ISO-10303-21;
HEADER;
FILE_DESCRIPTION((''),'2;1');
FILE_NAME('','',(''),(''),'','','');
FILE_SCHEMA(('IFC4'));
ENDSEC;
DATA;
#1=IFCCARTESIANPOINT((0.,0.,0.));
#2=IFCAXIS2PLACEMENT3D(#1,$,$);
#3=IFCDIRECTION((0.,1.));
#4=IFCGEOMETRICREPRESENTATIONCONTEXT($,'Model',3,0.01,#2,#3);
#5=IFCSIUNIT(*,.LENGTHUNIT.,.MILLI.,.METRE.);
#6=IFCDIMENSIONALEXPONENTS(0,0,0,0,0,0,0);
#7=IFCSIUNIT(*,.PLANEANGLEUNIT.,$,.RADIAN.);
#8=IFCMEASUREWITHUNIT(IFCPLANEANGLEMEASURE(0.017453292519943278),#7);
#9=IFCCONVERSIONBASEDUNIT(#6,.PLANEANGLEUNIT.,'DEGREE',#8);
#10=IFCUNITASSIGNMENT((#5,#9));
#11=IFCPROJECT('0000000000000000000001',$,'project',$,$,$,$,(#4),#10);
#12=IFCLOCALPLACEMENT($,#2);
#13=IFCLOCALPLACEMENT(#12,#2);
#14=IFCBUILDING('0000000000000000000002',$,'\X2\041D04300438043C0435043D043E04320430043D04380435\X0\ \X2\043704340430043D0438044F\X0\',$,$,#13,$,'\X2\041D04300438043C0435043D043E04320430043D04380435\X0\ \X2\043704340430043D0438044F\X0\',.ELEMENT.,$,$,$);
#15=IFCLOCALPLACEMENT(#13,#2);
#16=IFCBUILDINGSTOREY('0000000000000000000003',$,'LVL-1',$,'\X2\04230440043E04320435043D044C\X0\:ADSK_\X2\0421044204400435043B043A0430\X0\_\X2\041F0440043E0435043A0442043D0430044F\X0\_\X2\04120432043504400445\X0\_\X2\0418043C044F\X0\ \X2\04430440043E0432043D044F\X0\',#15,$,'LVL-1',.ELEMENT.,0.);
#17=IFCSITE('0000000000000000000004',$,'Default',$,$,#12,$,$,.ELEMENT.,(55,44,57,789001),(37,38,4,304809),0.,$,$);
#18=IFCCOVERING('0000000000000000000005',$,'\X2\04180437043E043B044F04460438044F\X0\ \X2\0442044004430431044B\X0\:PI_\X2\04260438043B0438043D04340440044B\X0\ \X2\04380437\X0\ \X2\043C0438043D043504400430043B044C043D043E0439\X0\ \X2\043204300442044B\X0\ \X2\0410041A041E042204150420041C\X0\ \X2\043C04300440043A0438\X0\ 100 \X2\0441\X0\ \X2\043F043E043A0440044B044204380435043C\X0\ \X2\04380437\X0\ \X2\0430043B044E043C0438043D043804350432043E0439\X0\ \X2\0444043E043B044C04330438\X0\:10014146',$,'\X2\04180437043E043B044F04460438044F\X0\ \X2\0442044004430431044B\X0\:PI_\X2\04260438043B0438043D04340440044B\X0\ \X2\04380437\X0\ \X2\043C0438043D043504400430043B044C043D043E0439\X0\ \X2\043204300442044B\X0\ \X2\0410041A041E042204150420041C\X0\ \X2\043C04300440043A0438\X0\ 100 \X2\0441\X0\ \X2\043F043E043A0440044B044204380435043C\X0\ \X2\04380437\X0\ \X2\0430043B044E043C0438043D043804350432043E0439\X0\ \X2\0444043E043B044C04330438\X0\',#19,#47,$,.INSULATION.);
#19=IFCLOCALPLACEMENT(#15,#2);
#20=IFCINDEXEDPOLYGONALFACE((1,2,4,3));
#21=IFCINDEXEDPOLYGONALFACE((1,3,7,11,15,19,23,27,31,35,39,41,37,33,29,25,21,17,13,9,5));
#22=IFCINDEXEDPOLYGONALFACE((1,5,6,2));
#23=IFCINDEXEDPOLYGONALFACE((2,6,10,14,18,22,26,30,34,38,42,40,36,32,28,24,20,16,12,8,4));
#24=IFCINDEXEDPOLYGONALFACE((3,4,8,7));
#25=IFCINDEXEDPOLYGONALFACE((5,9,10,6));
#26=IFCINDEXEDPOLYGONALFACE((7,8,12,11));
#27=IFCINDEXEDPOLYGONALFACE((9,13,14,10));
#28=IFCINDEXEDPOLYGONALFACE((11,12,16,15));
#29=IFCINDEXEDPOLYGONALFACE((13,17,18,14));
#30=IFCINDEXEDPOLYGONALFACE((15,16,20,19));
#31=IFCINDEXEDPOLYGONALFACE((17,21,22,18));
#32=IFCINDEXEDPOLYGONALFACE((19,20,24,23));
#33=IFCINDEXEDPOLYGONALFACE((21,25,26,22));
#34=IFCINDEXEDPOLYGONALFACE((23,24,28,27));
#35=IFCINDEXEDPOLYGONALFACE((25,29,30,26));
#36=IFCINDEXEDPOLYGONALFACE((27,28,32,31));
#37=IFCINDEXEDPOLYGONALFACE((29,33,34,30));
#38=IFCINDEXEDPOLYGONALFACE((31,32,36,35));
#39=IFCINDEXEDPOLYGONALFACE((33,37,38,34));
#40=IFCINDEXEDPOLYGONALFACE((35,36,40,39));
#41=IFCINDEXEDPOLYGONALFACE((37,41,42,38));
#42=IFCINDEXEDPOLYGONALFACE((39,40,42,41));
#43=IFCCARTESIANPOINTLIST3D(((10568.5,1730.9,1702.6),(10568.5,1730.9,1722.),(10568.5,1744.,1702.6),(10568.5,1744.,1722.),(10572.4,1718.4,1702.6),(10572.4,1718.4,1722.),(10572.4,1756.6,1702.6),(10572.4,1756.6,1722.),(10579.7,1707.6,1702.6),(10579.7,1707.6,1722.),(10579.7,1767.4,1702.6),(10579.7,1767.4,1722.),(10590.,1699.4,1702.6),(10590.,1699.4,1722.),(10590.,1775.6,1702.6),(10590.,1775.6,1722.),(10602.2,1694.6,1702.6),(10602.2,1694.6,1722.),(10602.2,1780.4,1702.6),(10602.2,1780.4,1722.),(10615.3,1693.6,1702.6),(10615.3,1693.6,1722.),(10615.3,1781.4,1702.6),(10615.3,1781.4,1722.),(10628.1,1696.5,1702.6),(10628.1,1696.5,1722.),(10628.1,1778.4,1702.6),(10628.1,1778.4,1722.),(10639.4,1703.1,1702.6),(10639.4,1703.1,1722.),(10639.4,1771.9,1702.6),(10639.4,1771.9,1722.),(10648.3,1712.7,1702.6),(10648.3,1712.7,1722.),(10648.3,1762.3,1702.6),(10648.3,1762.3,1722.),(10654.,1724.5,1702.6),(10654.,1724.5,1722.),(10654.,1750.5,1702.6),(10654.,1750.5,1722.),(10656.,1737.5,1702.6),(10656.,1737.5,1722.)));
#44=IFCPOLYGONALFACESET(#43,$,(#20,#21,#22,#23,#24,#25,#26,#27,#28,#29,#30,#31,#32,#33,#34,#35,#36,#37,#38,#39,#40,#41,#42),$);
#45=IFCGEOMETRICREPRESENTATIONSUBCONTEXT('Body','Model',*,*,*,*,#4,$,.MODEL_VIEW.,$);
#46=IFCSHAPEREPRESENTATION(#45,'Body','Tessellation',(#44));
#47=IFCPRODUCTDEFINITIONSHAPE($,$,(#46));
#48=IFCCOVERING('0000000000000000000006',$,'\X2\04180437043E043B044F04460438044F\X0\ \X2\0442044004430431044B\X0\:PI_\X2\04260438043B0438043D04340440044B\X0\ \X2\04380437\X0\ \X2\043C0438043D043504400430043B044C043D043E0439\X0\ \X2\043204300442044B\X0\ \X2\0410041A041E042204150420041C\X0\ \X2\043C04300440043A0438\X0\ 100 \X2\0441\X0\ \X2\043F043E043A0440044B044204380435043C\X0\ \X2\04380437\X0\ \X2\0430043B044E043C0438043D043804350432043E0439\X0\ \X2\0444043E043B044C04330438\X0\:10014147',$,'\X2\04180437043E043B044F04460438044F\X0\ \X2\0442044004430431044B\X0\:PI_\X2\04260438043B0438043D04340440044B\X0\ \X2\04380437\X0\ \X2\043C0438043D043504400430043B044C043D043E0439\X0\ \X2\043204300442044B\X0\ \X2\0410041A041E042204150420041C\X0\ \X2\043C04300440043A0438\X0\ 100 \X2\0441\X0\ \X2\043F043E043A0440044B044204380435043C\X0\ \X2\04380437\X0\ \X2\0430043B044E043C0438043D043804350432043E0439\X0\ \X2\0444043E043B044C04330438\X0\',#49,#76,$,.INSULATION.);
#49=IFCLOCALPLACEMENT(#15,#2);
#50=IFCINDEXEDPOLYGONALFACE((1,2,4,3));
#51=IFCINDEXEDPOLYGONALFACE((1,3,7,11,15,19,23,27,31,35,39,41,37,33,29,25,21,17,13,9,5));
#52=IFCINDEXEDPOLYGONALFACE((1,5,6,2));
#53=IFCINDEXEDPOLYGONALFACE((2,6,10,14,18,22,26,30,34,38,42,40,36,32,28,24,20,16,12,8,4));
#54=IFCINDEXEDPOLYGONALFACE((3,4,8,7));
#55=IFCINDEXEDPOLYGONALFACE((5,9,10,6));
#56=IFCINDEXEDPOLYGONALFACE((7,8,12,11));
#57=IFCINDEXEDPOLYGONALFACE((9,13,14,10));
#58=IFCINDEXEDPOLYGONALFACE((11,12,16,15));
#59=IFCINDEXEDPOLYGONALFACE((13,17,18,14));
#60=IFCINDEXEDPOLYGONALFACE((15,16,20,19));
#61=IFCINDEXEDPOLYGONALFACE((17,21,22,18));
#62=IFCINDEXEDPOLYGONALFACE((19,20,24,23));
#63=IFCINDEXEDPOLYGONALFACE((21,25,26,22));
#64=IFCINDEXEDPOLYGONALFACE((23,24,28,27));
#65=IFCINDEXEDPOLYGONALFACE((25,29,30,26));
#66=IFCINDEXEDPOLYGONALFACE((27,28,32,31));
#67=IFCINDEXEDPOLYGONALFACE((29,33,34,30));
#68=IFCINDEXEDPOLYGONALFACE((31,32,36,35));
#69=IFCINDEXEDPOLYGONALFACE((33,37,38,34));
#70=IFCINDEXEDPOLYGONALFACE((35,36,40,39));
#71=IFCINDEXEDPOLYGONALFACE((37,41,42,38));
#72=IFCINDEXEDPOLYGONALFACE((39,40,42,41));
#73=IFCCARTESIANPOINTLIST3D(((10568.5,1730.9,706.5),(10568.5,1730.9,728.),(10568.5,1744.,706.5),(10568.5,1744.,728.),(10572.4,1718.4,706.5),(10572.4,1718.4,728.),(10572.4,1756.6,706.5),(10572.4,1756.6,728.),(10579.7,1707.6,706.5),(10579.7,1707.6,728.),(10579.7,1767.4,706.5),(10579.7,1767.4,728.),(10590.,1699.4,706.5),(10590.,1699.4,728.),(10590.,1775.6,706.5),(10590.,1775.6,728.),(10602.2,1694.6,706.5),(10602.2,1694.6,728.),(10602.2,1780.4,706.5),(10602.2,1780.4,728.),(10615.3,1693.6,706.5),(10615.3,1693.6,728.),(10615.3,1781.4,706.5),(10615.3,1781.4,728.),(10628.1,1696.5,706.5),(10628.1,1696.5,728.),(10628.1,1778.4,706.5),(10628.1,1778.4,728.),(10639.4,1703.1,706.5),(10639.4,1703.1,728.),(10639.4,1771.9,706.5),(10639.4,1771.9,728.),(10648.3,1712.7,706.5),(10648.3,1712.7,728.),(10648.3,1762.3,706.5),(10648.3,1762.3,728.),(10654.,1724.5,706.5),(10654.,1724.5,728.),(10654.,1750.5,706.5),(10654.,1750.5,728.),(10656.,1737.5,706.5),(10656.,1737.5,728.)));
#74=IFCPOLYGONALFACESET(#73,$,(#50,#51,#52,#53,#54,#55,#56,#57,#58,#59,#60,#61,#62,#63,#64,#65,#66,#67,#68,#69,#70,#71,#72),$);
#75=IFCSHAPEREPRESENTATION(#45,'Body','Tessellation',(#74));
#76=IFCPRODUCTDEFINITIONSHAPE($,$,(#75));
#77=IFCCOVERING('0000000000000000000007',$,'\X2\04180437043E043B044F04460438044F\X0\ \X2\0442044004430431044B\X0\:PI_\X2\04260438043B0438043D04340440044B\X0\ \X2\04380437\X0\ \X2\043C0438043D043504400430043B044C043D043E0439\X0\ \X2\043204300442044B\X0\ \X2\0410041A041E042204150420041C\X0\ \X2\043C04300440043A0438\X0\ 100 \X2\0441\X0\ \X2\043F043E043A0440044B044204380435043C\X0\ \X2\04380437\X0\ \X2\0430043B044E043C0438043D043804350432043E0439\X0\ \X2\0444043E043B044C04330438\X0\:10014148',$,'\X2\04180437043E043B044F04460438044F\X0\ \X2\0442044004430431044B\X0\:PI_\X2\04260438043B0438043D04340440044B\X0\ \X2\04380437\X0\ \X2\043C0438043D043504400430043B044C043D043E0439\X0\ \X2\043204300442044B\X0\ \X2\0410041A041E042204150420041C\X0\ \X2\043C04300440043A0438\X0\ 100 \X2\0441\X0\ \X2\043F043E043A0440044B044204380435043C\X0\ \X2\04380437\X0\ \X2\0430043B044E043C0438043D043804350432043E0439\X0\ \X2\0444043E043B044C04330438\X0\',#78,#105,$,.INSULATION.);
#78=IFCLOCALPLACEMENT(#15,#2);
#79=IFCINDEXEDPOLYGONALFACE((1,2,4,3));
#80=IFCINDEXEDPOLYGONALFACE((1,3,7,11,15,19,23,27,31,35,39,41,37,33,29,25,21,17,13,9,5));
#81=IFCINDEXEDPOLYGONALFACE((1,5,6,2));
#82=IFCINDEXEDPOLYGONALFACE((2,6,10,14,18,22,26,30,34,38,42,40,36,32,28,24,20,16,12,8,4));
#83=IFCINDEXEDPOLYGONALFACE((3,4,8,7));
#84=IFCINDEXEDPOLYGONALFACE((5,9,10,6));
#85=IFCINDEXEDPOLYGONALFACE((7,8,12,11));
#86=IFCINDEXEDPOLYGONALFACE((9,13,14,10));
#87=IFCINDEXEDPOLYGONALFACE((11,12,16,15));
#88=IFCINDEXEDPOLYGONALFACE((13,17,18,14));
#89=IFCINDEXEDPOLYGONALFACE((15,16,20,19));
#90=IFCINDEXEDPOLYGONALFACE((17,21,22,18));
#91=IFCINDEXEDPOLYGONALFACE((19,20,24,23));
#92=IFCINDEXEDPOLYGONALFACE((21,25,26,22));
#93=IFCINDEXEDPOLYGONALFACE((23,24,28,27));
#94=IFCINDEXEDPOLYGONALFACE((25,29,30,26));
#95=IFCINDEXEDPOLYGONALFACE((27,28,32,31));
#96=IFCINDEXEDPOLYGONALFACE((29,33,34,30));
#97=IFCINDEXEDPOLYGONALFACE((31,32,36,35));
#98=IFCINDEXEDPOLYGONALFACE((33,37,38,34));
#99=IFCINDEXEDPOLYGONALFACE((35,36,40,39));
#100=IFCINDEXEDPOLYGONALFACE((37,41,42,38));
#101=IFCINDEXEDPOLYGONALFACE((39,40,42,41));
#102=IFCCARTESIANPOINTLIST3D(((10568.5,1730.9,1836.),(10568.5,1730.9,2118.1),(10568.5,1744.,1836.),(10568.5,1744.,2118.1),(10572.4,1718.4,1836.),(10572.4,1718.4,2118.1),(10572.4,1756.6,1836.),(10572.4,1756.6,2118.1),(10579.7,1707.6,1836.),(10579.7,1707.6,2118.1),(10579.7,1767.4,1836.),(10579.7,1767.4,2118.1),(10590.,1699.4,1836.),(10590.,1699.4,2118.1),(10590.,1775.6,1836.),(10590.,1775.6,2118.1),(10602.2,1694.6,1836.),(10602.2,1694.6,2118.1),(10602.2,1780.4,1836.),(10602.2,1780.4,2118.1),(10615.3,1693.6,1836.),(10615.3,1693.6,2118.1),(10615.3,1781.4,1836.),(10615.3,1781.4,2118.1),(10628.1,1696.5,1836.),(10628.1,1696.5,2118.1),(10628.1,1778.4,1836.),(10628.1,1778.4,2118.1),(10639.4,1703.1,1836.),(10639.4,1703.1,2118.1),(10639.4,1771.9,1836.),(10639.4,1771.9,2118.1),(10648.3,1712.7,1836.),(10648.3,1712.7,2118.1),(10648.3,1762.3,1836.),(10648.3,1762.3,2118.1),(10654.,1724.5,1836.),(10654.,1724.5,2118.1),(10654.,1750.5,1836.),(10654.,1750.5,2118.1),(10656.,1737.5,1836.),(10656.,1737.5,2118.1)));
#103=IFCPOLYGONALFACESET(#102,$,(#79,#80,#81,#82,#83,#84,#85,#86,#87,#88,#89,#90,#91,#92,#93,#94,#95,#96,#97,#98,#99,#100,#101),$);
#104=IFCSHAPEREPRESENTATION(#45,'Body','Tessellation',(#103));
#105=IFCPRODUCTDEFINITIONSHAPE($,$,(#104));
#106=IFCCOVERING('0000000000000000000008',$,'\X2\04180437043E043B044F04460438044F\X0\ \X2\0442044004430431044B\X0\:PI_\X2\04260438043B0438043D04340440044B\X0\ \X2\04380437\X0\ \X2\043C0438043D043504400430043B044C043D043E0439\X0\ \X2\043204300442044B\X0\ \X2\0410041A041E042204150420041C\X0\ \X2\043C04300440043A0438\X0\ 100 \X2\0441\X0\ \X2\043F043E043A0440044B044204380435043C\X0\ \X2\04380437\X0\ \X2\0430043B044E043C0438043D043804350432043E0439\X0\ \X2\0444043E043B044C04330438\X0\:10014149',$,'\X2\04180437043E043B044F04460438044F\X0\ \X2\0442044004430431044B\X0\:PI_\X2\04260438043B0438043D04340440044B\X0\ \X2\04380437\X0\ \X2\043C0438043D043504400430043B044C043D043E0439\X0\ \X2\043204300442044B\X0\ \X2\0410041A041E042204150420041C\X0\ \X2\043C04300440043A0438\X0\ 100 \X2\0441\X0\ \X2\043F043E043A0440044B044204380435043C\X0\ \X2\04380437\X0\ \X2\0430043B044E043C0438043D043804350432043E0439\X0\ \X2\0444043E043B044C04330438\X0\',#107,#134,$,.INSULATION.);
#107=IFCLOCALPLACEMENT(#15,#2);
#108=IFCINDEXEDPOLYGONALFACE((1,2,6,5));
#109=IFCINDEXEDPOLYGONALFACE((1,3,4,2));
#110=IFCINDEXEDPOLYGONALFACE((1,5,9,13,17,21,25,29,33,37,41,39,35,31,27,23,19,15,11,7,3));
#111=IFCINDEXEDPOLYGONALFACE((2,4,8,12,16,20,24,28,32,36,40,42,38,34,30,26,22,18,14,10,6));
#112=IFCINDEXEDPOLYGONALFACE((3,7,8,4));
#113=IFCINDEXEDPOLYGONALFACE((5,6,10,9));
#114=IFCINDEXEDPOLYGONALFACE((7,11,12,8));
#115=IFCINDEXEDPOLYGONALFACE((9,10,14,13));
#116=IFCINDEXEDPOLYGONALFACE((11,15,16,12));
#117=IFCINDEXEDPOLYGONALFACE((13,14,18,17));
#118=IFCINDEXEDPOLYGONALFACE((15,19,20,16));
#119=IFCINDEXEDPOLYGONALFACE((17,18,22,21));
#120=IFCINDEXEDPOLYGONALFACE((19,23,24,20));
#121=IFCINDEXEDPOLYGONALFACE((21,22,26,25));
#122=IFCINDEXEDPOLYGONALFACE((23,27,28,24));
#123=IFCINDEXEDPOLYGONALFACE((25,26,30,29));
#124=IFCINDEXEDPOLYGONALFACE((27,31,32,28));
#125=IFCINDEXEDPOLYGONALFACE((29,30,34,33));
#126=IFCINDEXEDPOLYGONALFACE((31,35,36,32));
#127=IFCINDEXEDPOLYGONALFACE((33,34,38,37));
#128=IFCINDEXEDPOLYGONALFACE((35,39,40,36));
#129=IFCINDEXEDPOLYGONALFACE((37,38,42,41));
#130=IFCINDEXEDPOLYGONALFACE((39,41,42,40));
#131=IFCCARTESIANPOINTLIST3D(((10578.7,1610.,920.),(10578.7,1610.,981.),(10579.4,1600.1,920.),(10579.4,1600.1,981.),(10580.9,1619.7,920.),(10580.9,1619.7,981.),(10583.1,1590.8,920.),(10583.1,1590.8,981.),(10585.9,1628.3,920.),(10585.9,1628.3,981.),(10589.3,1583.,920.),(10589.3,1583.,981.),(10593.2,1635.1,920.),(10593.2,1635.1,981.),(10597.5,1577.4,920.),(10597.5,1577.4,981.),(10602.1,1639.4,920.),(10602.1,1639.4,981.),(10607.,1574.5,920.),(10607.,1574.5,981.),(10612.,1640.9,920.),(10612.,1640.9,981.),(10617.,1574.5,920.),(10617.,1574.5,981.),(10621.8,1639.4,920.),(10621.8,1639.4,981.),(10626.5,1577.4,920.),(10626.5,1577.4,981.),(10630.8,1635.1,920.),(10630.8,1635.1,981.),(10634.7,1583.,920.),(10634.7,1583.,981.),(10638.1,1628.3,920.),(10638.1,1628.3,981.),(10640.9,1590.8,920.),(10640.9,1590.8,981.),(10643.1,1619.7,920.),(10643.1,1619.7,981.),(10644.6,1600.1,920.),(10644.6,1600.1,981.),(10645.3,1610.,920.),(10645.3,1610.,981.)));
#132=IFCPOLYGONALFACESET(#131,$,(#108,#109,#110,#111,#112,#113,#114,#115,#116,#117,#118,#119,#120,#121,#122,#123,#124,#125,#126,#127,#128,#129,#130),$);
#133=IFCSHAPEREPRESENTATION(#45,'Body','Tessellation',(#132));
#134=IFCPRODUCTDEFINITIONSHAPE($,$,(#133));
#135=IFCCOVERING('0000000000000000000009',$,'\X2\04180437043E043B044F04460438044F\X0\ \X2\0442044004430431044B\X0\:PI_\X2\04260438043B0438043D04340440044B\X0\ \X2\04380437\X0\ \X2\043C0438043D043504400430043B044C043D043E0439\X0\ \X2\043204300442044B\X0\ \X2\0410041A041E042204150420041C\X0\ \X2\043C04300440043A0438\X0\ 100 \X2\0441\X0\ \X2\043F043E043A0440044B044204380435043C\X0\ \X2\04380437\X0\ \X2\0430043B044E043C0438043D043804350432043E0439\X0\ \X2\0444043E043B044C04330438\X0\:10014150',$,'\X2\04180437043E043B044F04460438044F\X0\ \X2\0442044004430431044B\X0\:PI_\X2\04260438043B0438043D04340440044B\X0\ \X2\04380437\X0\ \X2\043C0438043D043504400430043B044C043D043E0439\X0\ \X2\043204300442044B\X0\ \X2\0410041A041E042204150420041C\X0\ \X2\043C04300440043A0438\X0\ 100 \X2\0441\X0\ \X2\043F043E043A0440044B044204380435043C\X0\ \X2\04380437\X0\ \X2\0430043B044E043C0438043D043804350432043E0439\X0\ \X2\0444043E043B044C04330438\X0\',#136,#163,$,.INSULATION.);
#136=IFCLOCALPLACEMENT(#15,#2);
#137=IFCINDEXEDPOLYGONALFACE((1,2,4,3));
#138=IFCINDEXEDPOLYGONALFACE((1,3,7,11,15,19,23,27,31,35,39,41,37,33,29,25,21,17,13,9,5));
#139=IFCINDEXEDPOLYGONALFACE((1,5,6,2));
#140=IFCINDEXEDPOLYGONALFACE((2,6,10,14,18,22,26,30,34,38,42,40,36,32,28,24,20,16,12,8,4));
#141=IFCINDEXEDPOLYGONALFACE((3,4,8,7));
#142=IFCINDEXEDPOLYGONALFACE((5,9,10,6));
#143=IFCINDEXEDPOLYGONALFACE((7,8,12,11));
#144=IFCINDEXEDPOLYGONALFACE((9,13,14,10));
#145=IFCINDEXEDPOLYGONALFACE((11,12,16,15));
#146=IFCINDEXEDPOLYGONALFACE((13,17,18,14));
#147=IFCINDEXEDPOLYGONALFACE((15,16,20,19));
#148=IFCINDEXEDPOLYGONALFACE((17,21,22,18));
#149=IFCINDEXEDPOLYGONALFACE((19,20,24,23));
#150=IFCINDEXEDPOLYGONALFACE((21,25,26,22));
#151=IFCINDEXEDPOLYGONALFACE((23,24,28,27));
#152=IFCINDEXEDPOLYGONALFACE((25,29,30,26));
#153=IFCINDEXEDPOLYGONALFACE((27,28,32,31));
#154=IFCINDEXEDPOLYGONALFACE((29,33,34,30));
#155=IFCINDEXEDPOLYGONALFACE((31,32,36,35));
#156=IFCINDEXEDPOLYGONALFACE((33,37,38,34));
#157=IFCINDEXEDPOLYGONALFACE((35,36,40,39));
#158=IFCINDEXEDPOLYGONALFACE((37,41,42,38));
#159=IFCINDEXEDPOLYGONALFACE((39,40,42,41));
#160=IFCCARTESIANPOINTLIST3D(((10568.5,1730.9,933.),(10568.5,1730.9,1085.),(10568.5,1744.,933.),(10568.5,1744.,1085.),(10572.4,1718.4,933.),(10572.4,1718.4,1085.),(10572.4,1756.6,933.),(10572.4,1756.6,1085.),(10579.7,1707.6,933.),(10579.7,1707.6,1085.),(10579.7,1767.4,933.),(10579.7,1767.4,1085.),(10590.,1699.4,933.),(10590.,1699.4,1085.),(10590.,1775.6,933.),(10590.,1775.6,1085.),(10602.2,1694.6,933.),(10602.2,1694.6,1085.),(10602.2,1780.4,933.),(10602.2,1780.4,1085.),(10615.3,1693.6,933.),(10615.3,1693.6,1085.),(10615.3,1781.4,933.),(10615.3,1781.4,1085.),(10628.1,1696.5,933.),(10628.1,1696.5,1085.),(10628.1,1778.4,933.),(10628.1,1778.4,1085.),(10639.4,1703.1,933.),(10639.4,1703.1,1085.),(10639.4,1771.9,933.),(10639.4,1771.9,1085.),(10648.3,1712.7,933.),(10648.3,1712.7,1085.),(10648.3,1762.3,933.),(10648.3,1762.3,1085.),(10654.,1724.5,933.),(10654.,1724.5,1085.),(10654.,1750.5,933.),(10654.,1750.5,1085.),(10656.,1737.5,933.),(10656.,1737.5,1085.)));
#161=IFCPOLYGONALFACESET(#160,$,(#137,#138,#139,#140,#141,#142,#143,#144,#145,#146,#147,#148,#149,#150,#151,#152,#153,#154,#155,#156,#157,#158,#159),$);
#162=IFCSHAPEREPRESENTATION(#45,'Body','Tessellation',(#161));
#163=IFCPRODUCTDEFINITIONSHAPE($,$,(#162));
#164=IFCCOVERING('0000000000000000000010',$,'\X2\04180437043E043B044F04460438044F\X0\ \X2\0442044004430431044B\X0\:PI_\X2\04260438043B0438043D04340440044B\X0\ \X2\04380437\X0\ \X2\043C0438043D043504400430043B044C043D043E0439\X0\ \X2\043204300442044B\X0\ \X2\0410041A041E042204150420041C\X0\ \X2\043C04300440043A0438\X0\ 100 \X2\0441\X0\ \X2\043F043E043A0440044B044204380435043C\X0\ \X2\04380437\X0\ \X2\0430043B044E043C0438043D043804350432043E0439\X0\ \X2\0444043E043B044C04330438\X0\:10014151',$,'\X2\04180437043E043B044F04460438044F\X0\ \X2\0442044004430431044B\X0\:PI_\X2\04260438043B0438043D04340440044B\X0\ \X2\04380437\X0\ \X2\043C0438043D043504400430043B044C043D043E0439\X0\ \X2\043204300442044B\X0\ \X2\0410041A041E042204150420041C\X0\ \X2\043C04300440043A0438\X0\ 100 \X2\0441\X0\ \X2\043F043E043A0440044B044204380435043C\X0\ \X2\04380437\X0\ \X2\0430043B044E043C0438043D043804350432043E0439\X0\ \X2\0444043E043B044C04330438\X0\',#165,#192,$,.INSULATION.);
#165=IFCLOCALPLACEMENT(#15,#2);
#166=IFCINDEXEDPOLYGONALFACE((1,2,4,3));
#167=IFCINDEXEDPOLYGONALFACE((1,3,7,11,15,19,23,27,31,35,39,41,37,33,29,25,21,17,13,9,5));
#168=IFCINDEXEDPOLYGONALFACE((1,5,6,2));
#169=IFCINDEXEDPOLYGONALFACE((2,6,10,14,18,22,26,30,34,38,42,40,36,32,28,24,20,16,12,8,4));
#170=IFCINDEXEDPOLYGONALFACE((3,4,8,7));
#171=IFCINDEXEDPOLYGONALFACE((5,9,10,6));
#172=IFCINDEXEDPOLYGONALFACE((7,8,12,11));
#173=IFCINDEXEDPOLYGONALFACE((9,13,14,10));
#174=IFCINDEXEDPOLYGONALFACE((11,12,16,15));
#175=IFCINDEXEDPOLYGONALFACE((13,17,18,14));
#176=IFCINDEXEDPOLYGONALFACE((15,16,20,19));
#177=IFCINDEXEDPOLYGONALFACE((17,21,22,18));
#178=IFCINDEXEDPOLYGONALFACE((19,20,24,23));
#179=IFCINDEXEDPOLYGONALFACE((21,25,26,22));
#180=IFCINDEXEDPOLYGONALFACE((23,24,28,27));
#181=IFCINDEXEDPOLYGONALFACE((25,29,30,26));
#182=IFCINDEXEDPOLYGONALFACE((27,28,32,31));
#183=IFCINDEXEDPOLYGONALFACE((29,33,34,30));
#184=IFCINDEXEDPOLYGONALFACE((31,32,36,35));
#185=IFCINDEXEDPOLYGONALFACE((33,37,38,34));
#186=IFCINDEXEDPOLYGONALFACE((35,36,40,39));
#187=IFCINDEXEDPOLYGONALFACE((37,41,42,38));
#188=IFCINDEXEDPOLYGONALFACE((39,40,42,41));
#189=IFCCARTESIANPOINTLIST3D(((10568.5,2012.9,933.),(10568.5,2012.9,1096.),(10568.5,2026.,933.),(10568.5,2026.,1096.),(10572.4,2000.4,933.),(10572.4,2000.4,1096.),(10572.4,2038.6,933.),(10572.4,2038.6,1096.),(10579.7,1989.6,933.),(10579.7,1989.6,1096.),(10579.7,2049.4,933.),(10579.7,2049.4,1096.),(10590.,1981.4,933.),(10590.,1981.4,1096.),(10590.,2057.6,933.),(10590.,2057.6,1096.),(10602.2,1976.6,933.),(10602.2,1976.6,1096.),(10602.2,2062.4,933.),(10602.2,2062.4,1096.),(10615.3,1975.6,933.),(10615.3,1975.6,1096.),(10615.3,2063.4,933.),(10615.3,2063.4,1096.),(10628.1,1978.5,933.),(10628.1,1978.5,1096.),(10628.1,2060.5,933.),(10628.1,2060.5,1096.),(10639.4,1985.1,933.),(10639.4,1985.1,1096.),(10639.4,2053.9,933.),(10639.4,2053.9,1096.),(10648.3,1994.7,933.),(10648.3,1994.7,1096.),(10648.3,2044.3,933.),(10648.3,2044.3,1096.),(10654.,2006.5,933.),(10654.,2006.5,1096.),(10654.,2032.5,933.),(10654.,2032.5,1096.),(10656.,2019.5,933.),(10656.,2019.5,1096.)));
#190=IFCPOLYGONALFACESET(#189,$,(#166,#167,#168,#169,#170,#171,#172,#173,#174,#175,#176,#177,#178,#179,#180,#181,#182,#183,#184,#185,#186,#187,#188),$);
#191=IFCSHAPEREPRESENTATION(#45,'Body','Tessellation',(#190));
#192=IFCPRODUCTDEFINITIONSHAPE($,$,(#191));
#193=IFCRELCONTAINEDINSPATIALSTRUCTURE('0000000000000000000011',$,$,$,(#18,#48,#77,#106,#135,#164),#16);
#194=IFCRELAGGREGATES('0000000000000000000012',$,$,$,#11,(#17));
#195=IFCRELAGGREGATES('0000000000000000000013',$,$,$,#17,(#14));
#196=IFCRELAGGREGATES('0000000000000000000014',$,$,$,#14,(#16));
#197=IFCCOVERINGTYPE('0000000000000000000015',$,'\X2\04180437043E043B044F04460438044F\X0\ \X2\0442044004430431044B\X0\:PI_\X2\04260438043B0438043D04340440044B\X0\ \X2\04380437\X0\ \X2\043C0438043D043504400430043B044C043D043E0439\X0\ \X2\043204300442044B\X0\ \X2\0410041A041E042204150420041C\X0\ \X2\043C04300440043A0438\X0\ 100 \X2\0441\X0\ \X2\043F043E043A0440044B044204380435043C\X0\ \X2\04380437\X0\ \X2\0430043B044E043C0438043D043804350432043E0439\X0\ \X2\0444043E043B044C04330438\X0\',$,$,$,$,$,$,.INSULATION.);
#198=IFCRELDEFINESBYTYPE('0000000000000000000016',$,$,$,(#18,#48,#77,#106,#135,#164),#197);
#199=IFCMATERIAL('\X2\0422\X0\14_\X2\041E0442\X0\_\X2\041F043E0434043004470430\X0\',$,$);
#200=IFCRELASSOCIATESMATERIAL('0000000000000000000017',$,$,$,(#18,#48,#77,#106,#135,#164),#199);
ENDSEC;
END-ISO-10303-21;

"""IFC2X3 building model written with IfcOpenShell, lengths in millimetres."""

from ifc_helpers import new_model, entity, si_unit, converted_unit, direction, frame, frame_2d, origin, origin_2d_with_axis, place, context, subcontext, project, spatial, circle, extrude, material, type_object, element, save


model = new_model("IFC2X3")

# Units and contexts
model_context = context("Model", 3, precision=0.01, world=origin(), true_north=direction((0.0, 1.0)))
body_context = subcontext(model_context, "Body", "Model", "MODEL_VIEW")
ifc_project = project(units=[si_unit("LENGTHUNIT", "METRE", prefix="MILLI"), converted_unit("PLANEANGLEUNIT", "DEGREE", entity("IfcPlaneAngleMeasure", 0.017453292519943278), si_unit("PLANEANGLEUNIT", "RADIAN"), dimensions=[0, 0, 0, 0, 0, 0, 0])], contexts=[model_context])

# Site, building, storey
site_placement = place(None, origin())
site = spatial("IfcSite", under=ifc_project, at=site_placement, Name="Default", CompositionType="ELEMENT", RefLatitude=(55, 44, 57, 789001), RefLongitude=(37, 38, 4, 304809), RefElevation=0.0)
building_placement = place(site_placement, origin())
building = spatial("IfcBuilding", under=site, at=building_placement, Name="Наименование здания", LongName="Наименование здания", CompositionType="ELEMENT")
storey_placement = place(building_placement, origin())
storey = spatial("IfcBuildingStorey", under=building, at=storey_placement, Name="LVL-1", ObjectType="Уровень:ADSK_Стрелка_Проектная_Вверх_Имя уровня", LongName="LVL-1", CompositionType="ELEMENT", Elevation=0.0)

# Coverings
ifc_material_1 = material(Name="Т14_От_Подача")
covering_type_1 = type_object("IfcCoveringType", Name="Изоляция трубы:PI_Цилиндры из минеральной ваты АКОТЕРМ марки 100 с покрытием из алюминиевой фольги", PredefinedType="INSULATION")
covering_1_placement = place(storey_placement, origin())
element("IfcCovering", 1, at=covering_1_placement, inside=storey, type_object=covering_type_1, material=ifc_material_1, Name="Изоляция трубы:PI_Цилиндры из минеральной ваты АКОТЕРМ марки 100 с покрытием из алюминиевой фольги:10014146", ObjectType="Изоляция трубы:PI_Цилиндры из минеральной ваты АКОТЕРМ марки 100 с покрытием из алюминиевой фольги", PredefinedType="INSULATION", context=body_context, shape_type="SweptSolid", body=[
    extrude(circle(Radius=44.0, at=frame_2d((0.0, 0.0), x_axis=(1.0, 0.0))), frame((10612.0, 1737.5, 1702.6)), (0.0, 0.0, 1.0), 19.4),
])
covering_2_placement = place(storey_placement, origin())
element("IfcCovering", 2, at=covering_2_placement, inside=storey, type_object=covering_type_1, material=ifc_material_1, Name="Изоляция трубы:PI_Цилиндры из минеральной ваты АКОТЕРМ марки 100 с покрытием из алюминиевой фольги:10014147", ObjectType="Изоляция трубы:PI_Цилиндры из минеральной ваты АКОТЕРМ марки 100 с покрытием из алюминиевой фольги", PredefinedType="INSULATION", context=body_context, shape_type="SweptSolid", body=[
    extrude(circle(Radius=44.0, at=frame_2d((0.0, 0.0), x_axis=(1.0, 0.0))), frame((10612.0, 1737.5, 706.5)), (0.0, 0.0, 1.0), 21.5),
])
covering_3_placement = place(storey_placement, origin())
element("IfcCovering", 3, at=covering_3_placement, inside=storey, type_object=covering_type_1, material=ifc_material_1, Name="Изоляция трубы:PI_Цилиндры из минеральной ваты АКОТЕРМ марки 100 с покрытием из алюминиевой фольги:10014148", ObjectType="Изоляция трубы:PI_Цилиндры из минеральной ваты АКОТЕРМ марки 100 с покрытием из алюминиевой фольги", PredefinedType="INSULATION", context=body_context, shape_type="SweptSolid", body=[
    extrude(circle(Radius=44.0, at=frame_2d((0.0, 0.0), x_axis=(1.0, 0.0))), frame((10612.0, 1737.5, 1836.0)), (0.0, 0.0, 1.0), 282.1),
])
covering_4_placement = place(storey_placement, origin())
element("IfcCovering", 4, at=covering_4_placement, inside=storey, type_object=covering_type_1, material=ifc_material_1, Name="Изоляция трубы:PI_Цилиндры из минеральной ваты АКОТЕРМ марки 100 с покрытием из алюминиевой фольги:10014149", ObjectType="Изоляция трубы:PI_Цилиндры из минеральной ваты АКОТЕРМ марки 100 с покрытием из алюминиевой фольги", PredefinedType="INSULATION", context=body_context, shape_type="SweptSolid", body=[
    extrude(circle(Radius=33.4, at=origin_2d_with_axis()), frame((10612.0, 1607.5, 920.0), z_axis=(0.0, 0.0, 1.0), x_axis=(0.0, 1.0, 0.0)), (0.0, 0.0, 1.0), 61.0),
])
covering_5_placement = place(storey_placement, origin())
element("IfcCovering", 5, at=covering_5_placement, inside=storey, type_object=covering_type_1, material=ifc_material_1, Name="Изоляция трубы:PI_Цилиндры из минеральной ваты АКОТЕРМ марки 100 с покрытием из алюминиевой фольги:10014150", ObjectType="Изоляция трубы:PI_Цилиндры из минеральной ваты АКОТЕРМ марки 100 с покрытием из алюминиевой фольги", PredefinedType="INSULATION", context=body_context, shape_type="SweptSolid", body=[
    extrude(circle(Radius=44.0, at=frame_2d((0.0, 0.0), x_axis=(1.0, 0.0))), frame((10612.0, 1737.5, 933.0)), (0.0, 0.0, 1.0), 152.0),
])
covering_6_placement = place(storey_placement, origin())
element("IfcCovering", 6, at=covering_6_placement, inside=storey, type_object=covering_type_1, material=ifc_material_1, Name="Изоляция трубы:PI_Цилиндры из минеральной ваты АКОТЕРМ марки 100 с покрытием из алюминиевой фольги:10014151", ObjectType="Изоляция трубы:PI_Цилиндры из минеральной ваты АКОТЕРМ марки 100 с покрытием из алюминиевой фольги", PredefinedType="INSULATION", context=body_context, shape_type="SweptSolid", body=[
    extrude(circle(Radius=44.0, at=frame_2d((0.0, 0.0), x_axis=(1.0, 0.0))), frame((10612.0, 2019.5, 933.0)), (0.0, 0.0, 1.0), 163.0),
])

save(model, "model.ifc")
